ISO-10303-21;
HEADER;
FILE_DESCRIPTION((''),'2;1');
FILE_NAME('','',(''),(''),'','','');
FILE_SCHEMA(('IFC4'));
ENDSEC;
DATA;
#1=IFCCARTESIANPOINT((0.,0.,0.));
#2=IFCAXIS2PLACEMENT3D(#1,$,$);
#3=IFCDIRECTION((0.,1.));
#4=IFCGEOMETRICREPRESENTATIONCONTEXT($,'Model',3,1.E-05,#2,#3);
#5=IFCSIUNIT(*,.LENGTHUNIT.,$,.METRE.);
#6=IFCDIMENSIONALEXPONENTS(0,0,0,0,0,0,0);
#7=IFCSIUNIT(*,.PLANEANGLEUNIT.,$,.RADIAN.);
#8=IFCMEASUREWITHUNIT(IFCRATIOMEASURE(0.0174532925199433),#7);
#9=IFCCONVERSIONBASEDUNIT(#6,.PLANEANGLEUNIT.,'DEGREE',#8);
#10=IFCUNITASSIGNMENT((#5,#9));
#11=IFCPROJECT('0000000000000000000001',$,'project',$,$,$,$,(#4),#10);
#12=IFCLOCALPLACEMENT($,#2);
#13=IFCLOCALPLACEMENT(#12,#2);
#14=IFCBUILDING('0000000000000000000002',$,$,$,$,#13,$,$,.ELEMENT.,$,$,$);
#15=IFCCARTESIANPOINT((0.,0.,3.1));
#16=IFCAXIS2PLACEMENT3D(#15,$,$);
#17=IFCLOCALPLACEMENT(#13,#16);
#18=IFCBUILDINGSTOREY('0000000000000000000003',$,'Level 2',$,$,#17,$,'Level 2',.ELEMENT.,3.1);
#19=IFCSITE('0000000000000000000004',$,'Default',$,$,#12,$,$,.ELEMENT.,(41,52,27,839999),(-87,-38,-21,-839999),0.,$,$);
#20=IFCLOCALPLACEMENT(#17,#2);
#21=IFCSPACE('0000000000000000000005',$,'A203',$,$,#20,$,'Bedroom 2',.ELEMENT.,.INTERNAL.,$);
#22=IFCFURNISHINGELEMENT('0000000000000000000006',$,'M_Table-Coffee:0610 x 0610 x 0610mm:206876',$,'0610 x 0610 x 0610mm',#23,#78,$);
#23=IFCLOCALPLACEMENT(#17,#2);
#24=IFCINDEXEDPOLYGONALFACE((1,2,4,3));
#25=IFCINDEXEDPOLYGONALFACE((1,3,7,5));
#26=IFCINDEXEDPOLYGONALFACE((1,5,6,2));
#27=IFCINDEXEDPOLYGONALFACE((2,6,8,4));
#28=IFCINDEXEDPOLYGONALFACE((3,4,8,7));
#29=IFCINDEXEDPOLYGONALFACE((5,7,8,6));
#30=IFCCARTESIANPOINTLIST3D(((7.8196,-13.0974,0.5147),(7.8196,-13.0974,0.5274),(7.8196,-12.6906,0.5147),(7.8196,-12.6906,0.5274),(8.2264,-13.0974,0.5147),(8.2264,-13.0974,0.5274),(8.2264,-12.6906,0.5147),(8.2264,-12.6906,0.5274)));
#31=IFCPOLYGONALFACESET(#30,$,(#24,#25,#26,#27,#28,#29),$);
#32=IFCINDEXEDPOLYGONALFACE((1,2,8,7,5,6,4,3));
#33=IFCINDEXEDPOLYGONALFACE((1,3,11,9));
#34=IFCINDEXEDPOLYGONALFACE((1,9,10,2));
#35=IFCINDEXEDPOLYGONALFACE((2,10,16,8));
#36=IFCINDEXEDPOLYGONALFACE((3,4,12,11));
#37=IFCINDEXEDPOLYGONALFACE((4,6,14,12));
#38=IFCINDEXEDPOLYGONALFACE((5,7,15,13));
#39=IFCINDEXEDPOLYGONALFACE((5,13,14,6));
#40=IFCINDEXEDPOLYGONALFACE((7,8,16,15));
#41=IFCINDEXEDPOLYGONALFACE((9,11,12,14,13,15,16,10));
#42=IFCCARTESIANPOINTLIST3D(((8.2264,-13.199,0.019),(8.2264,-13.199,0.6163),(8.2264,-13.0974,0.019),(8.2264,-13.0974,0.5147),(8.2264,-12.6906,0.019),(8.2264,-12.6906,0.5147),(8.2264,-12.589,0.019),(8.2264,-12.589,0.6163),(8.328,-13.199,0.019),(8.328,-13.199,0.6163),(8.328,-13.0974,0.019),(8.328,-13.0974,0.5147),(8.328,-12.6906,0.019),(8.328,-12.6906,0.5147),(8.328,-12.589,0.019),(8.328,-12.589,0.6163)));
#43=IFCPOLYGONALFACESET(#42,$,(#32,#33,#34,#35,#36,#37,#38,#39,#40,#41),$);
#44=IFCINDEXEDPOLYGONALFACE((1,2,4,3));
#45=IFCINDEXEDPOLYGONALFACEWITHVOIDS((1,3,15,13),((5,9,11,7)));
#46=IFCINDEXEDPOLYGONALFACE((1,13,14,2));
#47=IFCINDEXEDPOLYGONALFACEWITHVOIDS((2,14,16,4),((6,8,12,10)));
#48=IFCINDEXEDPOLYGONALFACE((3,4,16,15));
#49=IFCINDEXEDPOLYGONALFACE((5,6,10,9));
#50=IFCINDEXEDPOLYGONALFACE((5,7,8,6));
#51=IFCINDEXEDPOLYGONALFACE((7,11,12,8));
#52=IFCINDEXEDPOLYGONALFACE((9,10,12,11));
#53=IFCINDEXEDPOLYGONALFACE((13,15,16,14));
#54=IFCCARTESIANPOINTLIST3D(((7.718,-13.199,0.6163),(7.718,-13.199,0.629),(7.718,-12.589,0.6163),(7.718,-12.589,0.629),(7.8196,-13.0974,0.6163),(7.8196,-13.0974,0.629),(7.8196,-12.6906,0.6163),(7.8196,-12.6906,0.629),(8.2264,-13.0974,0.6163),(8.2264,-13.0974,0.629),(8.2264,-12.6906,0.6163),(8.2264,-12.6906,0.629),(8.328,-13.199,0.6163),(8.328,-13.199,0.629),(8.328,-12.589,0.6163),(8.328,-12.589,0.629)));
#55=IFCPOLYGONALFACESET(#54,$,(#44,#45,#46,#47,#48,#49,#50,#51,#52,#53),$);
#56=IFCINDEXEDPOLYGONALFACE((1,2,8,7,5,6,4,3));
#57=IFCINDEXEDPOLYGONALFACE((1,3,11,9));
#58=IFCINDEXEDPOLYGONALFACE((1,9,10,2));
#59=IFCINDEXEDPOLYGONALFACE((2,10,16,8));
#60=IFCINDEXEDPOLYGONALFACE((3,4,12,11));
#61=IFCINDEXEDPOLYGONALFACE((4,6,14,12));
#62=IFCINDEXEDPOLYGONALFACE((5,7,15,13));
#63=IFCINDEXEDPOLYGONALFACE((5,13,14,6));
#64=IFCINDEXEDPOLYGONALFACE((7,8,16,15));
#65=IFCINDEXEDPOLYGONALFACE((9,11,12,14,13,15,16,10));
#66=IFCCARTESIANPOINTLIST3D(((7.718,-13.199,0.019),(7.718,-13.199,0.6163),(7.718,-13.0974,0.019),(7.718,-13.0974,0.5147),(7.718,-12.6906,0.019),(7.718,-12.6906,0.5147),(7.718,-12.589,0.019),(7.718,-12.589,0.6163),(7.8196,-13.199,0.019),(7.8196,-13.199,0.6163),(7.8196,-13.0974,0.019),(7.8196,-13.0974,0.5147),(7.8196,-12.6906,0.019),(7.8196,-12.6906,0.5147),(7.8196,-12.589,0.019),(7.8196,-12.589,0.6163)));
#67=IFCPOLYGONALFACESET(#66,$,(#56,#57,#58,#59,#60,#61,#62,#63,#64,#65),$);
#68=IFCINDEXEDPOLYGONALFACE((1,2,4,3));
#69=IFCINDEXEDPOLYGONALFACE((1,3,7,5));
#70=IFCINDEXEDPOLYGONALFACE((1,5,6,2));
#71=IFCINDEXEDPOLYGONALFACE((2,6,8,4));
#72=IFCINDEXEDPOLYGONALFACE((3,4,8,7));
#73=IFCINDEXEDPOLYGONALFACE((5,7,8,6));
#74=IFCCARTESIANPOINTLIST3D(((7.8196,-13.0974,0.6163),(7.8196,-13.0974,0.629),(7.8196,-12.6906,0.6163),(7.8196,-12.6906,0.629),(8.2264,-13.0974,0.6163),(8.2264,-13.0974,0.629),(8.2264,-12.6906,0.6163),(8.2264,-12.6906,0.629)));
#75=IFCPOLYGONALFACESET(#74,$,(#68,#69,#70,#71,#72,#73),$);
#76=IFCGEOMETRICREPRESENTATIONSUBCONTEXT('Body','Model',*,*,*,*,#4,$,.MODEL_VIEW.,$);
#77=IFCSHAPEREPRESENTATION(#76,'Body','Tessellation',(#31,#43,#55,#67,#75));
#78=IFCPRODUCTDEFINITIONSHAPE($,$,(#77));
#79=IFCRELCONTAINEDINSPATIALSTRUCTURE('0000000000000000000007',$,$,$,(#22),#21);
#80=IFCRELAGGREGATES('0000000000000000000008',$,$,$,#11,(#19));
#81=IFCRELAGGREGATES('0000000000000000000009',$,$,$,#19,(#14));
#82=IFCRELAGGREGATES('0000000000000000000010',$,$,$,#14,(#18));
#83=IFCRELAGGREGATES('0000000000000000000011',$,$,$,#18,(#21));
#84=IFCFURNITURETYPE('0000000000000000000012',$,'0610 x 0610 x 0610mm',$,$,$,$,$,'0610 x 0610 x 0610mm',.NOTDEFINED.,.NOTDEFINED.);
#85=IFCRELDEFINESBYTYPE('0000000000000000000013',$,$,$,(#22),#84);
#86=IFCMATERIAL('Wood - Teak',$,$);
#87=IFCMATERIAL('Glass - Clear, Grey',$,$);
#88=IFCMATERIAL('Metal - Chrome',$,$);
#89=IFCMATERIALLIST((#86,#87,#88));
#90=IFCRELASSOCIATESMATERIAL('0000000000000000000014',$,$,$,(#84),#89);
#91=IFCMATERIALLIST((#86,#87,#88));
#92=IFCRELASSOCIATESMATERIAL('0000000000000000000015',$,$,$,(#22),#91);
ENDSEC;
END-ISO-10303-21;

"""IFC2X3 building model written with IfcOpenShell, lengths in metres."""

from ifc_helpers import new_model, entity, si_unit, converted_unit, direction, frame, origin, origin_2d_with_axis, place, context, subcontext, project, spatial, polyline, rectangle, outline, extrude, source, transform, mapped, material, material_list, type_object, type_shapes, element, save


model = new_model("IFC2X3")

# Units and contexts
model_context = context("Model", 3, precision=1e-05, world=origin(), true_north=direction((0.0, 1.0)))
body_context = subcontext(model_context, "Body", "Model", "MODEL_VIEW")
ifc_project = project(units=[si_unit("LENGTHUNIT", "METRE"), converted_unit("PLANEANGLEUNIT", "DEGREE", entity("IfcRatioMeasure", 0.0174532925199433), si_unit("PLANEANGLEUNIT", "RADIAN"), dimensions=[0, 0, 0, 0, 0, 0, 0])], contexts=[model_context])

# Site, building, storey
site_placement = place(None, origin())
site = spatial("IfcSite", under=ifc_project, at=site_placement, Name="Default", CompositionType="ELEMENT", RefLatitude=(41, 52, 27, 839999), RefLongitude=(-87, -38, -21, -839999), RefElevation=0.0)
building_placement = place(site_placement, origin())
building = spatial("IfcBuilding", under=site, at=building_placement, CompositionType="ELEMENT")
storey_placement = place(building_placement, frame((0.0, 0.0, 3.1)))
storey = spatial("IfcBuildingStorey", under=building, at=storey_placement, Name="Level 2", LongName="Level 2", CompositionType="ELEMENT", Elevation=3.1)

# Shared definitions
space_1_placement = place(storey_placement, origin())
space_1 = spatial("IfcSpace", under=storey, at=space_1_placement, Name="A203", LongName="Bedroom 2", CompositionType="ELEMENT", InteriorOrExteriorSpace="INTERNAL")

# Furnishing element
ifc_material_1 = material(Name="Wood - Teak")
ifc_material_2 = material(Name="Glass - Clear, Grey")
ifc_material_3 = material(Name="Metal - Chrome")
ifc_material_list_1 = material_list([ifc_material_1, ifc_material_2, ifc_material_3])
ifc_material_list_2 = material_list([ifc_material_1, ifc_material_2, ifc_material_3])
furniture_type_1 = type_object("IfcFurnitureType", Name="0610 x 0610 x 0610mm", ElementType="0610 x 0610 x 0610mm", AssemblyPlace="NOTDEFINED", material=ifc_material_list_2)
shared_shape_1 = source(origin(), body_context, "Body", "SweptSolid", [
    extrude(rectangle(XDim=0.4068, YDim=0.4068, at=origin_2d_with_axis()), frame((0.0183, 0.0952, 0.4957), z_axis=(0.0, 0.0, 1.0), x_axis=(-1.0, 0.0, 0.0)), (0.0, 0.0, 1.0), 0.0127),
    extrude(outline(polyline([(-0.2732, -0.305), (0.324, -0.305), (0.324, 0.305), (-0.2732, 0.305), (-0.2732, 0.2034), (0.2225, 0.2034), (0.2225, -0.2034), (-0.2732, -0.2034), (-0.2732, -0.305)])), frame((0.2217, 0.0952, 0.2732), z_axis=(1.0, 0.0, 0.0), x_axis=(0.0, 0.0, 1.0)), (0.0, 0.0, 1.0), 0.1016),
    extrude(outline(polyline([(-0.305, -0.305), (0.305, -0.305), (0.305, 0.305), (-0.305, 0.305), (-0.305, -0.305)]), holes=[polyline([(-0.2034, -0.2034), (-0.2034, 0.2034), (0.2034, 0.2034), (0.2034, -0.2034), (-0.2034, -0.2034)])]), frame((0.0183, 0.0952, 0.5973), z_axis=(0.0, 0.0, 1.0), x_axis=(-1.0, 0.0, 0.0)), (0.0, 0.0, 1.0), 0.0127),
    extrude(outline(polyline([(-0.305, -0.3241), (0.305, -0.3241), (0.305, 0.2733), (0.2034, 0.2733), (0.2034, -0.2224), (-0.2034, -0.2224), (-0.2034, 0.2733), (-0.305, 0.2733), (-0.305, -0.3241)])), frame((-0.2867, 0.0952, 0.2733), z_axis=(1.0, 0.0, 0.0), x_axis=(0.0, -1.0, 0.0)), (0.0, 0.0, 1.0), 0.1016),
    extrude(rectangle(XDim=0.4068, YDim=0.4068, at=origin_2d_with_axis()), frame((0.0183, 0.0952, 0.5973), z_axis=(0.0, 0.0, 1.0), x_axis=(-1.0, 0.0, 0.0)), (0.0, 0.0, 1.0), 0.0127),
])
type_shapes(furniture_type_1, [shared_shape_1])
furnishing_1_placement = place(space_1_placement, frame((8.0047, -12.9892, 0.019)))
element("IfcFurnishingElement", 1, at=furnishing_1_placement, inside=space_1, type_object=furniture_type_1, material=ifc_material_list_1, Name="M_Table-Coffee:0610 x 0610 x 0610mm:206876", ObjectType="0610 x 0610 x 0610mm", context=body_context, shape_type="MappedRepresentation", body=[
    mapped(shared_shape_1, transform((0.0, 0.0, 0.0), scale=1.0)),
])

save(model, "model.ifc")
